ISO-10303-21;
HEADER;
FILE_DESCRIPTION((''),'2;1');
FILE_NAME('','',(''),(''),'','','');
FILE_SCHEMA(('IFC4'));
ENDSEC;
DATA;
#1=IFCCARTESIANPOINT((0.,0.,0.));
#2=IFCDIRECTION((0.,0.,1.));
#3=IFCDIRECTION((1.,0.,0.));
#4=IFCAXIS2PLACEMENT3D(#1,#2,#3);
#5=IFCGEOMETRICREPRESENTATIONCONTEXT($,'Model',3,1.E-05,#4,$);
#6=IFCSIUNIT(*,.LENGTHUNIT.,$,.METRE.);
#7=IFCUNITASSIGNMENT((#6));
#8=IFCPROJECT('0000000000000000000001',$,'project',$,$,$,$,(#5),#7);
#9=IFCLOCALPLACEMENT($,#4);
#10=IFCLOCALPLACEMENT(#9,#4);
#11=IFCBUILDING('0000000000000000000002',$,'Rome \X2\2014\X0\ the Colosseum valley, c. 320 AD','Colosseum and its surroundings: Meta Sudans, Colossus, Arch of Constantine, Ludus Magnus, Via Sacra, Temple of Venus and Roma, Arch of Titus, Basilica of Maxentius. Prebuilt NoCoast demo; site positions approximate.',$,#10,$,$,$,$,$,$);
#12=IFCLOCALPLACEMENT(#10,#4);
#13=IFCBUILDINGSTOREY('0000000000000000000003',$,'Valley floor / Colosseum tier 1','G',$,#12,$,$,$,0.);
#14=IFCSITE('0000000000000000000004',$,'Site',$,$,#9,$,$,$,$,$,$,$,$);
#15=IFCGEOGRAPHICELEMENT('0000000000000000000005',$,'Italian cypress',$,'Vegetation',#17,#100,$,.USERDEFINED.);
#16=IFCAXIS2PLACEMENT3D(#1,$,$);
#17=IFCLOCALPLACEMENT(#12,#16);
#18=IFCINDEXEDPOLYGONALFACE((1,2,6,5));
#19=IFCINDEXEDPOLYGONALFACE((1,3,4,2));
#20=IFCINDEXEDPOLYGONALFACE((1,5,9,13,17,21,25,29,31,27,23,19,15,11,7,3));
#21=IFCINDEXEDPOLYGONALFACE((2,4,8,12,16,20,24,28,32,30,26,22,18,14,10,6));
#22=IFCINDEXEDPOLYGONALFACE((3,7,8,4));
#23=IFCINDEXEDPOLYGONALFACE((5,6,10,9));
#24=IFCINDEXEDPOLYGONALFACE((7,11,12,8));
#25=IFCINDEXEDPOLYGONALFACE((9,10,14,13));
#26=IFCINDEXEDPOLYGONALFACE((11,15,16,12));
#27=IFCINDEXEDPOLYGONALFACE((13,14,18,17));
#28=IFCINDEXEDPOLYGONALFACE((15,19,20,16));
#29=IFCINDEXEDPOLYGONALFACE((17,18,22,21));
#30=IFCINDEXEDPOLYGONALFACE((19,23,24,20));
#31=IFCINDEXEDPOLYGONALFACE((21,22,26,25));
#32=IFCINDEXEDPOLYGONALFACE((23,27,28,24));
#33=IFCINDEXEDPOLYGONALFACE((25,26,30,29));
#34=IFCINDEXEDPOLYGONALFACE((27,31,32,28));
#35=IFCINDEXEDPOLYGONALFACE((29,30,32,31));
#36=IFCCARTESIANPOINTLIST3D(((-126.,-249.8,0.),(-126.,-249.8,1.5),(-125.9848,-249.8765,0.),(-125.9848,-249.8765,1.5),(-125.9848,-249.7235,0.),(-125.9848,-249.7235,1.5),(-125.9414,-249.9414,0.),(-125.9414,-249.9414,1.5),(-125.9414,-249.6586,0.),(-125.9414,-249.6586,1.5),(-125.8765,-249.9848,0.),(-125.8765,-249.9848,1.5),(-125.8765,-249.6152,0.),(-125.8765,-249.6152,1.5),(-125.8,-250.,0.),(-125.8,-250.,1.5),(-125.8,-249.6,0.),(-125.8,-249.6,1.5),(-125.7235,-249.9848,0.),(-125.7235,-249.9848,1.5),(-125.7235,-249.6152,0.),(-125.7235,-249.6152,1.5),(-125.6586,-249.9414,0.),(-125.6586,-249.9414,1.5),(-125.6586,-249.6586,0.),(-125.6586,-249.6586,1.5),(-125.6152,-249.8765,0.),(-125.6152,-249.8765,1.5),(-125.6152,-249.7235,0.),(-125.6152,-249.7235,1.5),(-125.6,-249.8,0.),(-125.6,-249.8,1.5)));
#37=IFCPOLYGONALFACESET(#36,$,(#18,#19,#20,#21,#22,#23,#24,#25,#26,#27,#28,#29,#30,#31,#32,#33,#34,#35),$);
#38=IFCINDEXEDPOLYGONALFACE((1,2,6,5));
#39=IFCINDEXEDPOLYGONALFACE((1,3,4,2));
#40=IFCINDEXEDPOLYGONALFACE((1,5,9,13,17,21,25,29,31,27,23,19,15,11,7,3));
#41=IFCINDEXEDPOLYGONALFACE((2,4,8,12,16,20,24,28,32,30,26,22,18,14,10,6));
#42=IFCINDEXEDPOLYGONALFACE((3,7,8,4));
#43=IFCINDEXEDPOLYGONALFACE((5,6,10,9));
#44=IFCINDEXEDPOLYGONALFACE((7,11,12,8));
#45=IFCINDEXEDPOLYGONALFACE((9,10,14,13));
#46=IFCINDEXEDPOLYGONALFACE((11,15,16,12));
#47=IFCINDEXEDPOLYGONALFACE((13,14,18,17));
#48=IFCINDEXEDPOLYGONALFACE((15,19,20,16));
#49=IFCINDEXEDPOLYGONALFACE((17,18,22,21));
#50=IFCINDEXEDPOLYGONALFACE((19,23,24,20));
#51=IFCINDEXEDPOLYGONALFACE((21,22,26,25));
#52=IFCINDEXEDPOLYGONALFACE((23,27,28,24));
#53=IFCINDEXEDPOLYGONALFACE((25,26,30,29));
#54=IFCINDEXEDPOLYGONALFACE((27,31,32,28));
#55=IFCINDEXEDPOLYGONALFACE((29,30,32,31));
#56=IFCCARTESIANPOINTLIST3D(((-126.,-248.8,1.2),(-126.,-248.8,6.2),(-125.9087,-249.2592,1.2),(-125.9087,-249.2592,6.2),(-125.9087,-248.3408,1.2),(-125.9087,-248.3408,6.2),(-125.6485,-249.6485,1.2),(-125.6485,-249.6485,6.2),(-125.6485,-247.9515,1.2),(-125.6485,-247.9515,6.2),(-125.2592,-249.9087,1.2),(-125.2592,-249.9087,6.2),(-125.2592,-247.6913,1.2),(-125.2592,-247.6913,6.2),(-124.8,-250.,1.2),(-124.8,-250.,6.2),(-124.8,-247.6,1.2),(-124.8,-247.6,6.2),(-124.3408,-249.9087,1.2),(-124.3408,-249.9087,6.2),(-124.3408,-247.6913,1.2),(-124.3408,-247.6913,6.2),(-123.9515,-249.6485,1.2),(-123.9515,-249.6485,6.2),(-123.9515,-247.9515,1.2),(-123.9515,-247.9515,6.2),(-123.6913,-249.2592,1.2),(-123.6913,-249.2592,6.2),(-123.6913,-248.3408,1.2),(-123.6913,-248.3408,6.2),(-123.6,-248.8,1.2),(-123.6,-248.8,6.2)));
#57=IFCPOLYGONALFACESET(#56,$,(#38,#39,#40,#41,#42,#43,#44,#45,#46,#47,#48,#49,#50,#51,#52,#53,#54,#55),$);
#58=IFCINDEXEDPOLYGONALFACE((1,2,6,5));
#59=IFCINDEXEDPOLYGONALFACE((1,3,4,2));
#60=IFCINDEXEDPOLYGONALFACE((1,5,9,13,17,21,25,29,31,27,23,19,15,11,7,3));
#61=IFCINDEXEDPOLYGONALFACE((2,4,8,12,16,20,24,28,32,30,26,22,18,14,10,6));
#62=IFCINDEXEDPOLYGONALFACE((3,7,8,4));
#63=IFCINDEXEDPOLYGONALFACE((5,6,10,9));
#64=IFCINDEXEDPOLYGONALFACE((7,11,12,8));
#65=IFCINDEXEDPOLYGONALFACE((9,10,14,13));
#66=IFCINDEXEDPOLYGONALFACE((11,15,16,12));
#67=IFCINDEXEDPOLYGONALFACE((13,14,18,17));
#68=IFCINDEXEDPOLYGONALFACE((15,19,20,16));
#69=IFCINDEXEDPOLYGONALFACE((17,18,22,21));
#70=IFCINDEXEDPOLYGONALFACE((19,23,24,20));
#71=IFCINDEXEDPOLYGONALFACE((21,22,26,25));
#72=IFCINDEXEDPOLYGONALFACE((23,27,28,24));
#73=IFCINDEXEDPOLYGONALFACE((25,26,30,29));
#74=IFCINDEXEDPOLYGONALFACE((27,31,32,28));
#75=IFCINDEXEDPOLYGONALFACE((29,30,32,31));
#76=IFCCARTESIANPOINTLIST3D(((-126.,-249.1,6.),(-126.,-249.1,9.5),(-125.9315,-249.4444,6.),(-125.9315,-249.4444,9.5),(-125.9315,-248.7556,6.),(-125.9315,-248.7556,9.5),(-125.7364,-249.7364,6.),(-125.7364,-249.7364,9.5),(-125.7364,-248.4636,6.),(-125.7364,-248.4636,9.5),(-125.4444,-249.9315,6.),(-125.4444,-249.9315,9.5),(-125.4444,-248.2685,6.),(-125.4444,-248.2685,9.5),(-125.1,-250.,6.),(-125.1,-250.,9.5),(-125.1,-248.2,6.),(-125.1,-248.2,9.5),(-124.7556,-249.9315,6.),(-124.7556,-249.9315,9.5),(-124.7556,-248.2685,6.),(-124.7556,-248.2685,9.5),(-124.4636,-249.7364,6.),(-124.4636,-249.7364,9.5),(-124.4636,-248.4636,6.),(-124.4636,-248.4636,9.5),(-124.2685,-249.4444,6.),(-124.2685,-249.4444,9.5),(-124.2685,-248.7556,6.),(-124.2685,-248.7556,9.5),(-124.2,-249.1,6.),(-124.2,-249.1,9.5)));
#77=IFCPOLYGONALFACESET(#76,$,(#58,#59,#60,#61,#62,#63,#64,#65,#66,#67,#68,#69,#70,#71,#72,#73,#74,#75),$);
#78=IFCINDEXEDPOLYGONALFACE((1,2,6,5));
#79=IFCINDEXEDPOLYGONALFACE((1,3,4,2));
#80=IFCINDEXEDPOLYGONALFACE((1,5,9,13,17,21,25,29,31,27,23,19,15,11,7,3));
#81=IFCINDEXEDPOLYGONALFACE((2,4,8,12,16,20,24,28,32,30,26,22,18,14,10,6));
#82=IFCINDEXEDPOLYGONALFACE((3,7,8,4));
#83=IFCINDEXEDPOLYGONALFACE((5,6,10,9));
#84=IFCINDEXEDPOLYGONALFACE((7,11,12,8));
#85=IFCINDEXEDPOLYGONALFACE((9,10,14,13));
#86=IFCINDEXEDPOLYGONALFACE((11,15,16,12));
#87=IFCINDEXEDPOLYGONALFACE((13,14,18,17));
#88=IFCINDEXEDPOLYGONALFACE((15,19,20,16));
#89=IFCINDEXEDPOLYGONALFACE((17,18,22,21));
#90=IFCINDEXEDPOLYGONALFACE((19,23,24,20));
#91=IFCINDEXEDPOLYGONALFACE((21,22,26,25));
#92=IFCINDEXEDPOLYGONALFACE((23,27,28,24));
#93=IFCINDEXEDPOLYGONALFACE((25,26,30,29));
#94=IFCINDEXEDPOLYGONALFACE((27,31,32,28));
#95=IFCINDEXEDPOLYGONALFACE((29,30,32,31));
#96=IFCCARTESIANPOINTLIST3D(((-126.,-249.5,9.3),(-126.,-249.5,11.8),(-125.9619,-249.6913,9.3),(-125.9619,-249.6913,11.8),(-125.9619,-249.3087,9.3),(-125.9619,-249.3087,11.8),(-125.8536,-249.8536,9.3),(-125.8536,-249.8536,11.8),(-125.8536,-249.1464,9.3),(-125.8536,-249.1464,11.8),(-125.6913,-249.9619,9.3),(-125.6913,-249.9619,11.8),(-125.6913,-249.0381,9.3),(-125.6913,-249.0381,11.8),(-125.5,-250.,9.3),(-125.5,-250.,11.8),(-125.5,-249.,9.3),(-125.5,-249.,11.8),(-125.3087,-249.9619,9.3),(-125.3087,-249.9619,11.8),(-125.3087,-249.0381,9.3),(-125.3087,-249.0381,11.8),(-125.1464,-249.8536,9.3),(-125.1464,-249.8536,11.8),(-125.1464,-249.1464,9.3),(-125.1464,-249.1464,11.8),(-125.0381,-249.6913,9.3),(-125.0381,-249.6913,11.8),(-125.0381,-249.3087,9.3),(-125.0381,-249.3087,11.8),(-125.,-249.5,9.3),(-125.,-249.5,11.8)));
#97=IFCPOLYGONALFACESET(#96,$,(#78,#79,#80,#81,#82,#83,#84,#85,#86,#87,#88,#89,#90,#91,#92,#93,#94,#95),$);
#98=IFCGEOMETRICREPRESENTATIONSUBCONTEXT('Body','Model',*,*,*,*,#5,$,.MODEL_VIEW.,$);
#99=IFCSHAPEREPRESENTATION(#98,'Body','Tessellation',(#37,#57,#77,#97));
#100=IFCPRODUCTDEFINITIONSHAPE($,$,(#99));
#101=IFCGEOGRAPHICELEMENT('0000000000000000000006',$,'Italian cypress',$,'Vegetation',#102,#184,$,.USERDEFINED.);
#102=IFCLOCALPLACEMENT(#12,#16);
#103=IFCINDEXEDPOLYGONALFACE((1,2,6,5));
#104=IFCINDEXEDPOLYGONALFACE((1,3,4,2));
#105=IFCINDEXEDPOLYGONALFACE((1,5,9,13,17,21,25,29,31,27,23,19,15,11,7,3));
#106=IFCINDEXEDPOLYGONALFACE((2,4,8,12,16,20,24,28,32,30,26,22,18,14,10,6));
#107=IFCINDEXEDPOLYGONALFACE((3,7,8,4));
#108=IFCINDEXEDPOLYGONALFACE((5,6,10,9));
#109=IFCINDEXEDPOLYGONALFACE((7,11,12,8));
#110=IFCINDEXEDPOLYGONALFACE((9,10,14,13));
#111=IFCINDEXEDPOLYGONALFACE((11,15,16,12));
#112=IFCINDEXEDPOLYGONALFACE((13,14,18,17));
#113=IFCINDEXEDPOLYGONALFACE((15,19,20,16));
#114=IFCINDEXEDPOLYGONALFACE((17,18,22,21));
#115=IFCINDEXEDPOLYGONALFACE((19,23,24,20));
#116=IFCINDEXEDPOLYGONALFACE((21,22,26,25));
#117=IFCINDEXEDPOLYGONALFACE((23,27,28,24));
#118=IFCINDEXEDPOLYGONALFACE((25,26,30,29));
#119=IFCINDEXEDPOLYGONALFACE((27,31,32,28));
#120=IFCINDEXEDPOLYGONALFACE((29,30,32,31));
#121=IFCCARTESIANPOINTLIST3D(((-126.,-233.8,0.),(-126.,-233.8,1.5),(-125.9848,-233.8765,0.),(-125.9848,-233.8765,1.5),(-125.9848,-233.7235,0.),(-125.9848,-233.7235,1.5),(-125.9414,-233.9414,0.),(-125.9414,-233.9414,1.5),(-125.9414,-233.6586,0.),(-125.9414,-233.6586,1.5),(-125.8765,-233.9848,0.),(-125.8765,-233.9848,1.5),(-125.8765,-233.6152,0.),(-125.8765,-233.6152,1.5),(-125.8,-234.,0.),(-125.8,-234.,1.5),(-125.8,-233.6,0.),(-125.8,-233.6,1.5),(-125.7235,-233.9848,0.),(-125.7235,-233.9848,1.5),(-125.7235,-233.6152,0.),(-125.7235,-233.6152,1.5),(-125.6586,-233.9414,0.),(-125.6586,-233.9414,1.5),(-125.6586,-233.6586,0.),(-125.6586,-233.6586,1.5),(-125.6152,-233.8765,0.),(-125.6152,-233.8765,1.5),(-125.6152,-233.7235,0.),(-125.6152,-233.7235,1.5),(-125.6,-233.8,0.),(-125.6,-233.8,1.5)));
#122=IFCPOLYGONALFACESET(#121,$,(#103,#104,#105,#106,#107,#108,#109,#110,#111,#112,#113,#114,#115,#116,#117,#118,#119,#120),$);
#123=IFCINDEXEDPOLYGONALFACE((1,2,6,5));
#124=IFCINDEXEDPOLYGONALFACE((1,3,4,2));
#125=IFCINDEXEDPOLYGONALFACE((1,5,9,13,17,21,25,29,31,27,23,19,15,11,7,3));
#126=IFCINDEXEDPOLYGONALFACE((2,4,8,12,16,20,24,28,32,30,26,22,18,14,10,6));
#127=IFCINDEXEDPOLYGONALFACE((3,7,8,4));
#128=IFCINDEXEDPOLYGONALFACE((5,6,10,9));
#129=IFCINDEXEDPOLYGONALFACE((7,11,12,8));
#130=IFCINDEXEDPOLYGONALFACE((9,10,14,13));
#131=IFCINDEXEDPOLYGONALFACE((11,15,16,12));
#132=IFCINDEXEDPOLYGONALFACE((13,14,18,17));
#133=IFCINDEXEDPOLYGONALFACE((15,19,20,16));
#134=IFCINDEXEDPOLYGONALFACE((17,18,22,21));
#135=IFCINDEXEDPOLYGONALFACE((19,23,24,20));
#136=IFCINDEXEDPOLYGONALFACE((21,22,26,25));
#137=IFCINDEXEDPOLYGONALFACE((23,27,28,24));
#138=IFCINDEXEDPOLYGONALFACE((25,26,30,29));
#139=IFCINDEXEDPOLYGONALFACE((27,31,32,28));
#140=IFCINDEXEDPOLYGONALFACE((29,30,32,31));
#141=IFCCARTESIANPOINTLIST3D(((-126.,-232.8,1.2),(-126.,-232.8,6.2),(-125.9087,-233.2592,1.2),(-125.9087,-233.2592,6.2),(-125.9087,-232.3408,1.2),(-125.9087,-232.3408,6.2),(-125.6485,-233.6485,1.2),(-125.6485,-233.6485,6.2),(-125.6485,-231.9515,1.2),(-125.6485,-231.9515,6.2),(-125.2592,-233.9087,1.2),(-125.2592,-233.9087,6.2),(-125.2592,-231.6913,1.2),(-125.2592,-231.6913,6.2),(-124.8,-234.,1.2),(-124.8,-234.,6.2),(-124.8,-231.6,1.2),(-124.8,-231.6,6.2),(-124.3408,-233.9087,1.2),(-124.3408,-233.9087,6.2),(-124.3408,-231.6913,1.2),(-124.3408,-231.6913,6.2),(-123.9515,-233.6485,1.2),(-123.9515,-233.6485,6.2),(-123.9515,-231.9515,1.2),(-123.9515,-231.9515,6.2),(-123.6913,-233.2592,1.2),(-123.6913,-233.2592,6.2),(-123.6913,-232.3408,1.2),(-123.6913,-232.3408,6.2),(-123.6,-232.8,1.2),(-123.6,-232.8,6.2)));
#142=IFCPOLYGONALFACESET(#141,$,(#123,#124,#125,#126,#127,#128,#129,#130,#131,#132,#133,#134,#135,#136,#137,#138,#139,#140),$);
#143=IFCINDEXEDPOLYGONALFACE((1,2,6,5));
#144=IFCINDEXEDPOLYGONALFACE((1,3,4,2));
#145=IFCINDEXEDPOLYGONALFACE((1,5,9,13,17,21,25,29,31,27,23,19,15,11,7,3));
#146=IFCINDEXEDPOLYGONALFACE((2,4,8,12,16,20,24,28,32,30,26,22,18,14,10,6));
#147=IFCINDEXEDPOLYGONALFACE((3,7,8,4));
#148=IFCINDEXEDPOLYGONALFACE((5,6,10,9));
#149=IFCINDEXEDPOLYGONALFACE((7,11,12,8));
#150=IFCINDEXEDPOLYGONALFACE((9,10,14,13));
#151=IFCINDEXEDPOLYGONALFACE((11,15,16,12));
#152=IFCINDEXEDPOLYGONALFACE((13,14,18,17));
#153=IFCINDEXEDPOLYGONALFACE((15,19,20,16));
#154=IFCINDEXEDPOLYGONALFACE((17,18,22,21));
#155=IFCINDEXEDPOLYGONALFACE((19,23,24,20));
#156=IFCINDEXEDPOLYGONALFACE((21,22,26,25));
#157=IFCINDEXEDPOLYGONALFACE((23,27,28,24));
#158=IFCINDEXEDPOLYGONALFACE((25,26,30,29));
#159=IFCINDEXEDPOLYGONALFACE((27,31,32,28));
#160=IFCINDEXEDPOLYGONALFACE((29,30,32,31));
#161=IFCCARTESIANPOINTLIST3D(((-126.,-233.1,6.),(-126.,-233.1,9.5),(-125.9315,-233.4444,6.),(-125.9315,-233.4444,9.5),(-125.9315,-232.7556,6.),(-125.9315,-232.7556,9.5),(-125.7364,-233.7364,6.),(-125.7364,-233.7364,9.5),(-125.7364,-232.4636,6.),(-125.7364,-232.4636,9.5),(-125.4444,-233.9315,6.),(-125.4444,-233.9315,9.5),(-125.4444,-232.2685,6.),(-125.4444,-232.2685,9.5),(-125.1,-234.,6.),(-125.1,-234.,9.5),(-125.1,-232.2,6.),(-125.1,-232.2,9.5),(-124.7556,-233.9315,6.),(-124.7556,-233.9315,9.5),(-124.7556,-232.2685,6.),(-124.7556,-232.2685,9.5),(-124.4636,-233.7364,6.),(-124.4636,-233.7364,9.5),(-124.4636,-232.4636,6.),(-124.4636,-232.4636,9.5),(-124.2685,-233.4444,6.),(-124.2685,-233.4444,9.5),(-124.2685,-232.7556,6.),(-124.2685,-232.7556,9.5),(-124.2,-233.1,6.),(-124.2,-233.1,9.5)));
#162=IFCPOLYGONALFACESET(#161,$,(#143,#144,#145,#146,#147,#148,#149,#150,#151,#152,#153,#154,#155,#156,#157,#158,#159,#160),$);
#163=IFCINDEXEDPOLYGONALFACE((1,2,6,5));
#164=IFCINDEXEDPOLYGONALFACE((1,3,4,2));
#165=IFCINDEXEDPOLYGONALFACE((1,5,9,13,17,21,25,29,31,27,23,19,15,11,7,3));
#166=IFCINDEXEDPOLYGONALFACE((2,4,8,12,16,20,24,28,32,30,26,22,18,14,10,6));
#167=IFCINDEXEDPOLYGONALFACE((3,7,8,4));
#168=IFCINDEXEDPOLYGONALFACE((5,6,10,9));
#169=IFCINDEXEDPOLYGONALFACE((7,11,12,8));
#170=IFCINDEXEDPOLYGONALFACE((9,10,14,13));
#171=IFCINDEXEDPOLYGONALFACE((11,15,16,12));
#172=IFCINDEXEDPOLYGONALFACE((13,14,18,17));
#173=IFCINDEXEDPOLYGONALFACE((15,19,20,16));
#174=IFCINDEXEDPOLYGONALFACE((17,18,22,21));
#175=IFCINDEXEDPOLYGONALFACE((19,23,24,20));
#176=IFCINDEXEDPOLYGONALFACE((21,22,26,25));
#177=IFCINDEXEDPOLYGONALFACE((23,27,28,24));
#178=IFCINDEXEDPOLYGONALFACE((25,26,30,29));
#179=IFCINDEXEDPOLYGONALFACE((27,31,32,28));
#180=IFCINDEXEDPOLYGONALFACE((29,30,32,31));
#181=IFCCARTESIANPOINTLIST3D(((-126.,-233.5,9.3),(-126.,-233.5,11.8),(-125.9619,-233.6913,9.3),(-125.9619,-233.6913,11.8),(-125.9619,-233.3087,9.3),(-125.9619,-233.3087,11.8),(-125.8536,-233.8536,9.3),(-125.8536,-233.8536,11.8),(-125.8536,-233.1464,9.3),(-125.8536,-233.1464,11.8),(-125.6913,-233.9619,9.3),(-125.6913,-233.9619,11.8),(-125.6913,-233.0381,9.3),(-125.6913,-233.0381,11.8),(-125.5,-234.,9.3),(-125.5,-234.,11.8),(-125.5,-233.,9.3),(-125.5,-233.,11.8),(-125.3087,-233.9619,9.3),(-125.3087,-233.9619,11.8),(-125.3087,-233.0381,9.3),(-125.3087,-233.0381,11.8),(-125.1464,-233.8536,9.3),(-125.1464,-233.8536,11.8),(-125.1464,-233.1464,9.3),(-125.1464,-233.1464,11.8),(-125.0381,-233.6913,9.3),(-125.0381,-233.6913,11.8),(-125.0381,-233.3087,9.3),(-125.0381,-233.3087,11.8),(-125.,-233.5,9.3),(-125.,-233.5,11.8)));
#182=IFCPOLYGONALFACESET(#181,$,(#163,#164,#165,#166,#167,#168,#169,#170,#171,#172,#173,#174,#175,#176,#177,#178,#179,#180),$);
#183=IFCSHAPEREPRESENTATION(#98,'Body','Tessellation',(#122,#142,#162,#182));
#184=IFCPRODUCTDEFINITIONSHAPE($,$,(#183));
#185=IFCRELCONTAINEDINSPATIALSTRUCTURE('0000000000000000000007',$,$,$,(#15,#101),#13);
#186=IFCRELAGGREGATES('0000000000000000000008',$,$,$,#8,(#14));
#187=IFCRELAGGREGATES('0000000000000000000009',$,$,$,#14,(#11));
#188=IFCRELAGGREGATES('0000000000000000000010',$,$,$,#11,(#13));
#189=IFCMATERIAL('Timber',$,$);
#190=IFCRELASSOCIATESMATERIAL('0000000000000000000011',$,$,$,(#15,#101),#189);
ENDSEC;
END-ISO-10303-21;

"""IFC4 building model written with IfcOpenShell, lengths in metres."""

from ifc_helpers import new_model, si_unit, frame, origin_with_axes, place, context, subcontext, project, spatial, polyline, outline, extrude, material, element, save


model = new_model("IFC4")

# Units and contexts
model_context = context("Model", 3, precision=1e-05, world=origin_with_axes())
body_context = subcontext(model_context, "Body", "Model", "MODEL_VIEW")
ifc_project = project(units=[si_unit("LENGTHUNIT", "METRE")], contexts=[model_context])

# Site, building, storey
site_placement = place(None, origin_with_axes())
site = spatial("IfcSite", under=ifc_project, at=site_placement, Name="Site")
building_placement = place(site_placement, origin_with_axes())
building = spatial("IfcBuilding", under=site, at=building_placement, Name="Rome — the Colosseum valley, c. 320 AD", Description="Colosseum and its surroundings: Meta Sudans, Colossus, Arch of Constantine, Ludus Magnus, Via Sacra, Temple of Venus and Roma, Arch of Titus, Basilica of Maxentius. Prebuilt NoCoast demo; site positions approximate.")
storey_placement = place(building_placement, origin_with_axes())
storey = spatial("IfcBuildingStorey", under=building, at=storey_placement, Name="Valley floor / Colosseum tier 1", Description="G", Elevation=0.0)

# Shared definitions
ifc_material_1 = material(Name="Timber")

# Geographic elements
geographic_element_1_placement = place(storey_placement, frame((-126.0, -250.0, 0.0), z_axis=(0.0, 0.0, 1.0), x_axis=(1.0, 0.0, 0.0)))
element("IfcGeographicElement", 1, at=geographic_element_1_placement, inside=storey, material=ifc_material_1, Name="Italian cypress", ObjectType="Vegetation", PredefinedType="USERDEFINED", context=body_context, shape_type="SweptSolid", body=[
    extrude(outline(polyline([(0.4, 0.2), (0.3848, 0.2765), (0.3414, 0.3414), (0.2765, 0.3848), (0.2, 0.4), (0.1235, 0.3848), (0.0586, 0.3414), (0.0152, 0.2765), (0.0, 0.2), (0.0152, 0.1235), (0.0586, 0.0586), (0.1235, 0.0152), (0.2, 0.0), (0.2765, 0.0152), (0.3414, 0.0586), (0.3848, 0.1235), (0.4, 0.2)])), origin_with_axes(), (0.0, 0.0, 1.0), 1.5),
    extrude(outline(polyline([(2.4, 1.2), (2.3087, 1.6592), (2.0485, 2.0485), (1.6592, 2.3087), (1.2, 2.4), (0.7408, 2.3087), (0.3515, 2.0485), (0.0913, 1.6592), (0.0, 1.2), (0.0913, 0.7408), (0.3515, 0.3515), (0.7408, 0.0913), (1.2, 0.0), (1.6592, 0.0913), (2.0485, 0.3515), (2.3087, 0.7408), (2.4, 1.2)])), frame((0.0, 0.0, 1.2), z_axis=(0.0, 0.0, 1.0), x_axis=(1.0, 0.0, 0.0)), (0.0, 0.0, 1.0), 5.0),
    extrude(outline(polyline([(1.8, 0.9), (1.7315, 1.2444), (1.5364, 1.5364), (1.2444, 1.7315), (0.9, 1.8), (0.5556, 1.7315), (0.2636, 1.5364), (0.0685, 1.2444), (0.0, 0.9), (0.0685, 0.5556), (0.2636, 0.2636), (0.5556, 0.0685), (0.9, 0.0), (1.2444, 0.0685), (1.5364, 0.2636), (1.7315, 0.5556), (1.8, 0.9)])), frame((0.0, 0.0, 6.0), z_axis=(0.0, 0.0, 1.0), x_axis=(1.0, 0.0, 0.0)), (0.0, 0.0, 1.0), 3.5),
    extrude(outline(polyline([(1.0, 0.5), (0.9619, 0.6913), (0.8536, 0.8536), (0.6913, 0.9619), (0.5, 1.0), (0.3087, 0.9619), (0.1464, 0.8536), (0.0381, 0.6913), (0.0, 0.5), (0.0381, 0.3087), (0.1464, 0.1464), (0.3087, 0.0381), (0.5, 0.0), (0.6913, 0.0381), (0.8536, 0.1464), (0.9619, 0.3087), (1.0, 0.5)])), frame((0.0, 0.0, 9.3), z_axis=(0.0, 0.0, 1.0), x_axis=(1.0, 0.0, 0.0)), (0.0, 0.0, 1.0), 2.5),
])
geographic_element_2_placement = place(storey_placement, frame((-126.0, -234.0, 0.0), z_axis=(0.0, 0.0, 1.0), x_axis=(1.0, 0.0, 0.0)))
element("IfcGeographicElement", 2, at=geographic_element_2_placement, inside=storey, material=ifc_material_1, Name="Italian cypress", ObjectType="Vegetation", PredefinedType="USERDEFINED", context=body_context, shape_type="SweptSolid", body=[
    extrude(outline(polyline([(0.4, 0.2), (0.3848, 0.2765), (0.3414, 0.3414), (0.2765, 0.3848), (0.2, 0.4), (0.1235, 0.3848), (0.0586, 0.3414), (0.0152, 0.2765), (0.0, 0.2), (0.0152, 0.1235), (0.0586, 0.0586), (0.1235, 0.0152), (0.2, 0.0), (0.2765, 0.0152), (0.3414, 0.0586), (0.3848, 0.1235), (0.4, 0.2)])), origin_with_axes(), (0.0, 0.0, 1.0), 1.5),
    extrude(outline(polyline([(2.4, 1.2), (2.3087, 1.6592), (2.0485, 2.0485), (1.6592, 2.3087), (1.2, 2.4), (0.7408, 2.3087), (0.3515, 2.0485), (0.0913, 1.6592), (0.0, 1.2), (0.0913, 0.7408), (0.3515, 0.3515), (0.7408, 0.0913), (1.2, 0.0), (1.6592, 0.0913), (2.0485, 0.3515), (2.3087, 0.7408), (2.4, 1.2)])), frame((0.0, 0.0, 1.2), z_axis=(0.0, 0.0, 1.0), x_axis=(1.0, 0.0, 0.0)), (0.0, 0.0, 1.0), 5.0),
    extrude(outline(polyline([(1.8, 0.9), (1.7315, 1.2444), (1.5364, 1.5364), (1.2444, 1.7315), (0.9, 1.8), (0.5556, 1.7315), (0.2636, 1.5364), (0.0685, 1.2444), (0.0, 0.9), (0.0685, 0.5556), (0.2636, 0.2636), (0.5556, 0.0685), (0.9, 0.0), (1.2444, 0.0685), (1.5364, 0.2636), (1.7315, 0.5556), (1.8, 0.9)])), frame((0.0, 0.0, 6.0), z_axis=(0.0, 0.0, 1.0), x_axis=(1.0, 0.0, 0.0)), (0.0, 0.0, 1.0), 3.5),
    extrude(outline(polyline([(1.0, 0.5), (0.9619, 0.6913), (0.8536, 0.8536), (0.6913, 0.9619), (0.5, 1.0), (0.3087, 0.9619), (0.1464, 0.8536), (0.0381, 0.6913), (0.0, 0.5), (0.0381, 0.3087), (0.1464, 0.1464), (0.3087, 0.0381), (0.5, 0.0), (0.6913, 0.0381), (0.8536, 0.1464), (0.9619, 0.3087), (1.0, 0.5)])), frame((0.0, 0.0, 9.3), z_axis=(0.0, 0.0, 1.0), x_axis=(1.0, 0.0, 0.0)), (0.0, 0.0, 1.0), 2.5),
])

save(model, "model.ifc")
